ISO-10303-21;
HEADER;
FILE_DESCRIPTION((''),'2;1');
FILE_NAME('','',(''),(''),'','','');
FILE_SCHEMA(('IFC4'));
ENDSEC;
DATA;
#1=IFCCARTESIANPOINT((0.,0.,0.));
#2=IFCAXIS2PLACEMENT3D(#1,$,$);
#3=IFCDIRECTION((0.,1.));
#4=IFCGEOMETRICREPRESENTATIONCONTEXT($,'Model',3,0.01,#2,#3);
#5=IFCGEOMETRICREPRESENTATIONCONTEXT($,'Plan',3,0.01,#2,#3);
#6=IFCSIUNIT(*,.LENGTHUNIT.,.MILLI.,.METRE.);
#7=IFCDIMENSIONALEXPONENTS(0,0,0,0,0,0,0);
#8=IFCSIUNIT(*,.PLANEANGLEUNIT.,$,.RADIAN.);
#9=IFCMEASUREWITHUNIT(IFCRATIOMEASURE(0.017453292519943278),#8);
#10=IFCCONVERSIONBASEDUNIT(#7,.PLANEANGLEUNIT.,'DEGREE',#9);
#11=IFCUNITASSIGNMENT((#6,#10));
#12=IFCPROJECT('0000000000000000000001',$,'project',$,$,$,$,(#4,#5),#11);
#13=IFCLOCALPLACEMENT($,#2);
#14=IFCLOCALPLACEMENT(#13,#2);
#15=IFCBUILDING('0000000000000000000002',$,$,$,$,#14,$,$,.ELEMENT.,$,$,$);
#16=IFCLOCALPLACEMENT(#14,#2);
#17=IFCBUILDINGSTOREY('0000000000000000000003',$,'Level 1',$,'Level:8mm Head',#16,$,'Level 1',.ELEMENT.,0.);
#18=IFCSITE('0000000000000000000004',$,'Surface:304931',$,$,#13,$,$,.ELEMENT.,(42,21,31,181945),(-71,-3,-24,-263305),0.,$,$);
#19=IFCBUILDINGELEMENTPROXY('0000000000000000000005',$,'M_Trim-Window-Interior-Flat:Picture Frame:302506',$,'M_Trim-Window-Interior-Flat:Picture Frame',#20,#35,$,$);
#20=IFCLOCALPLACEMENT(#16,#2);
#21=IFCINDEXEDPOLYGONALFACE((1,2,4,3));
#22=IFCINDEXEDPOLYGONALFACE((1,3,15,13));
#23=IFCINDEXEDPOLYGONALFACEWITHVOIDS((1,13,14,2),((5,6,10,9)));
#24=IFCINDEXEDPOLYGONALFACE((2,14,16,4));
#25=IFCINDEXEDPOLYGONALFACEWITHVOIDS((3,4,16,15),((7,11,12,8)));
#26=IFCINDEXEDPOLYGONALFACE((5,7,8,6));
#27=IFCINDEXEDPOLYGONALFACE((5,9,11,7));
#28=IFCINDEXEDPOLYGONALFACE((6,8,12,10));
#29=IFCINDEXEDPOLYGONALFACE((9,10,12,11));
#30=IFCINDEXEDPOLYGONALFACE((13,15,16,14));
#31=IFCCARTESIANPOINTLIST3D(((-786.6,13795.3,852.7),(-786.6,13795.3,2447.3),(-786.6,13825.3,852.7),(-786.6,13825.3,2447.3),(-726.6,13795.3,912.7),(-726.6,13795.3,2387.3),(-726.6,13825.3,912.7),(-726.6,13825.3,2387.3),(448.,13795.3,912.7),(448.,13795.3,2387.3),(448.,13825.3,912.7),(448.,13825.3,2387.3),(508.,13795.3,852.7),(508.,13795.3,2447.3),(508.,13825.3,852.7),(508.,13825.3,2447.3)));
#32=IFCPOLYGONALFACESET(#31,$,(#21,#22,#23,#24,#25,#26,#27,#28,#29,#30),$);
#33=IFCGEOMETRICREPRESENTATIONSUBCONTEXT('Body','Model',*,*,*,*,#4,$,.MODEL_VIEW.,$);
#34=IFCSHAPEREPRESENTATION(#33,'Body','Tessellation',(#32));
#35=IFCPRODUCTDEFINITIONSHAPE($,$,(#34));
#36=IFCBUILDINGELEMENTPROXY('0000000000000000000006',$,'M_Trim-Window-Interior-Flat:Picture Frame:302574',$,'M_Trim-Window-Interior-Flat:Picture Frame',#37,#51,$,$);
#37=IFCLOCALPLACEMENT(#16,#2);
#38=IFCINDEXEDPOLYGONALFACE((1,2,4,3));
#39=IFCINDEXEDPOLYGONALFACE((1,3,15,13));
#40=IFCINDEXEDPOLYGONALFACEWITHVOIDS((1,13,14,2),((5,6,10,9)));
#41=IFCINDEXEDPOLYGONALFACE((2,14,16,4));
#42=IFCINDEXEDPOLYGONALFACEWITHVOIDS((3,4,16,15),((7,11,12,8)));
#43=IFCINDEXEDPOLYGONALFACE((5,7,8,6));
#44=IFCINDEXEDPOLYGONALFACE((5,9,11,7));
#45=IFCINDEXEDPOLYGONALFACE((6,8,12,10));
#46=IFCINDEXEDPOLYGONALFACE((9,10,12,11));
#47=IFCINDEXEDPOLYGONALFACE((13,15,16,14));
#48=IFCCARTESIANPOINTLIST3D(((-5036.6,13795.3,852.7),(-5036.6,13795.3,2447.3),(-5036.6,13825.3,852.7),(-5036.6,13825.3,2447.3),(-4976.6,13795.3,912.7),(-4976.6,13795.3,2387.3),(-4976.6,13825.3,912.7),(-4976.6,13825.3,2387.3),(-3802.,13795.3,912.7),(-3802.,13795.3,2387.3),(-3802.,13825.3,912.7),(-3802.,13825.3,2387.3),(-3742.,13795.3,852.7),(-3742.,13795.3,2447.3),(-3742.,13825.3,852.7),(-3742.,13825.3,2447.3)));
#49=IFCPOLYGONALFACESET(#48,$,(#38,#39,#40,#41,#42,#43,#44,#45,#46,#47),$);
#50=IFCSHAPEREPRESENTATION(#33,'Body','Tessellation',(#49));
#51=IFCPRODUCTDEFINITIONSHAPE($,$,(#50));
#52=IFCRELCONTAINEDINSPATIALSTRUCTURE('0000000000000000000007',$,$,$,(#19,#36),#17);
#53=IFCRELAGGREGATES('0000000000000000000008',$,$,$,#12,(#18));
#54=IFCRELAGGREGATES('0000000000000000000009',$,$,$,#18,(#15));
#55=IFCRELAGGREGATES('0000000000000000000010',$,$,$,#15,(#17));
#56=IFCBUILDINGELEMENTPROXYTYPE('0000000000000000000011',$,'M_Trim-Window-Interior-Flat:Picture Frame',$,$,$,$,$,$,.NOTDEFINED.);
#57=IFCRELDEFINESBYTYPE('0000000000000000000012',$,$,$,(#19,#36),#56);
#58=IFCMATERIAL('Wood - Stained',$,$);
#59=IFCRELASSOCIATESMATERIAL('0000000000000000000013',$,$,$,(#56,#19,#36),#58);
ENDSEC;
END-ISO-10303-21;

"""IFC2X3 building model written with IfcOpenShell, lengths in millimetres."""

from ifc_helpers import new_model, entity, si_unit, converted_unit, direction, frame, origin, place, context, subcontext, project, spatial, polyline, outline, extrude, source, transform, mapped, material, type_object, type_shapes, element, save


model = new_model("IFC2X3")

# Units and contexts
model_context = context("Model", 3, precision=0.01, world=origin(), true_north=direction((0.0, 1.0)))
plan_context = context("Plan", 3, precision=0.01, world=origin(), true_north=direction((0.0, 1.0)))
body_context = subcontext(model_context, "Body", "Model", "MODEL_VIEW")
ifc_project = project(units=[si_unit("LENGTHUNIT", "METRE", prefix="MILLI"), converted_unit("PLANEANGLEUNIT", "DEGREE", entity("IfcRatioMeasure", 0.017453292519943278), si_unit("PLANEANGLEUNIT", "RADIAN"), dimensions=[0, 0, 0, 0, 0, 0, 0])], contexts=[model_context, plan_context])

# Site, building, storey
site_placement = place(None, origin())
site = spatial("IfcSite", under=ifc_project, at=site_placement, Name="Surface:304931", CompositionType="ELEMENT", RefLatitude=(42, 21, 31, 181945), RefLongitude=(-71, -3, -24, -263305), RefElevation=0.0)
building_placement = place(site_placement, origin())
building = spatial("IfcBuilding", under=site, at=building_placement, CompositionType="ELEMENT")
storey_placement = place(building_placement, origin())
storey = spatial("IfcBuildingStorey", under=building, at=storey_placement, Name="Level 1", ObjectType="Level:8mm Head", LongName="Level 1", CompositionType="ELEMENT", Elevation=0.0)

# Building element proxies
ifc_material_1 = material(Name="Wood - Stained")
building_element_proxy_type_1 = type_object("IfcBuildingElementProxyType", Name="M_Trim-Window-Interior-Flat:Picture Frame", PredefinedType="NOTDEFINED", material=ifc_material_1)
shared_shape_1 = source(origin(), body_context, "Body", "SweptSolid", [
    extrude(outline(polyline([(-647.3, -797.3), (647.3, -797.3), (647.3, 797.3), (-647.3, 797.3), (-647.3, -797.3)]), holes=[polyline([(-587.3, -737.3), (-587.3, 737.3), (587.3, 737.3), (587.3, -737.3), (-587.3, -737.3)])]), frame((0.0, -750.0, 0.0), z_axis=(0.0, 0.0, 1.0), x_axis=(-1.0, 0.0, 0.0)), (0.0, 0.0, 1.0), 30.0),
])
type_shapes(building_element_proxy_type_1, [shared_shape_1])
for number, where, z_axis, x_axis, name in (
    (1, (-139.3, 13825.3, 2400.0), (0.0, -1.0, 0.0), (1.0, 0.0, 0.0), "M_Trim-Window-Interior-Flat:Picture Frame:302506"),
    (2, (-4389.3, 13825.3, 2400.0), (0.0, -1.0, 0.0), (1.0, 0.0, 0.0), "M_Trim-Window-Interior-Flat:Picture Frame:302574"),
):
    element("IfcBuildingElementProxy", number, at=place(storey_placement, frame(where, z_axis=z_axis, x_axis=x_axis)), inside=storey, type_object=building_element_proxy_type_1, material=ifc_material_1, Name=name, ObjectType="M_Trim-Window-Interior-Flat:Picture Frame", context=body_context, shape_type="MappedRepresentation", body=[
        mapped(shared_shape_1, transform((0.0, 0.0, 0.0), scale=1.0)),
    ])

save(model, "model.ifc")
